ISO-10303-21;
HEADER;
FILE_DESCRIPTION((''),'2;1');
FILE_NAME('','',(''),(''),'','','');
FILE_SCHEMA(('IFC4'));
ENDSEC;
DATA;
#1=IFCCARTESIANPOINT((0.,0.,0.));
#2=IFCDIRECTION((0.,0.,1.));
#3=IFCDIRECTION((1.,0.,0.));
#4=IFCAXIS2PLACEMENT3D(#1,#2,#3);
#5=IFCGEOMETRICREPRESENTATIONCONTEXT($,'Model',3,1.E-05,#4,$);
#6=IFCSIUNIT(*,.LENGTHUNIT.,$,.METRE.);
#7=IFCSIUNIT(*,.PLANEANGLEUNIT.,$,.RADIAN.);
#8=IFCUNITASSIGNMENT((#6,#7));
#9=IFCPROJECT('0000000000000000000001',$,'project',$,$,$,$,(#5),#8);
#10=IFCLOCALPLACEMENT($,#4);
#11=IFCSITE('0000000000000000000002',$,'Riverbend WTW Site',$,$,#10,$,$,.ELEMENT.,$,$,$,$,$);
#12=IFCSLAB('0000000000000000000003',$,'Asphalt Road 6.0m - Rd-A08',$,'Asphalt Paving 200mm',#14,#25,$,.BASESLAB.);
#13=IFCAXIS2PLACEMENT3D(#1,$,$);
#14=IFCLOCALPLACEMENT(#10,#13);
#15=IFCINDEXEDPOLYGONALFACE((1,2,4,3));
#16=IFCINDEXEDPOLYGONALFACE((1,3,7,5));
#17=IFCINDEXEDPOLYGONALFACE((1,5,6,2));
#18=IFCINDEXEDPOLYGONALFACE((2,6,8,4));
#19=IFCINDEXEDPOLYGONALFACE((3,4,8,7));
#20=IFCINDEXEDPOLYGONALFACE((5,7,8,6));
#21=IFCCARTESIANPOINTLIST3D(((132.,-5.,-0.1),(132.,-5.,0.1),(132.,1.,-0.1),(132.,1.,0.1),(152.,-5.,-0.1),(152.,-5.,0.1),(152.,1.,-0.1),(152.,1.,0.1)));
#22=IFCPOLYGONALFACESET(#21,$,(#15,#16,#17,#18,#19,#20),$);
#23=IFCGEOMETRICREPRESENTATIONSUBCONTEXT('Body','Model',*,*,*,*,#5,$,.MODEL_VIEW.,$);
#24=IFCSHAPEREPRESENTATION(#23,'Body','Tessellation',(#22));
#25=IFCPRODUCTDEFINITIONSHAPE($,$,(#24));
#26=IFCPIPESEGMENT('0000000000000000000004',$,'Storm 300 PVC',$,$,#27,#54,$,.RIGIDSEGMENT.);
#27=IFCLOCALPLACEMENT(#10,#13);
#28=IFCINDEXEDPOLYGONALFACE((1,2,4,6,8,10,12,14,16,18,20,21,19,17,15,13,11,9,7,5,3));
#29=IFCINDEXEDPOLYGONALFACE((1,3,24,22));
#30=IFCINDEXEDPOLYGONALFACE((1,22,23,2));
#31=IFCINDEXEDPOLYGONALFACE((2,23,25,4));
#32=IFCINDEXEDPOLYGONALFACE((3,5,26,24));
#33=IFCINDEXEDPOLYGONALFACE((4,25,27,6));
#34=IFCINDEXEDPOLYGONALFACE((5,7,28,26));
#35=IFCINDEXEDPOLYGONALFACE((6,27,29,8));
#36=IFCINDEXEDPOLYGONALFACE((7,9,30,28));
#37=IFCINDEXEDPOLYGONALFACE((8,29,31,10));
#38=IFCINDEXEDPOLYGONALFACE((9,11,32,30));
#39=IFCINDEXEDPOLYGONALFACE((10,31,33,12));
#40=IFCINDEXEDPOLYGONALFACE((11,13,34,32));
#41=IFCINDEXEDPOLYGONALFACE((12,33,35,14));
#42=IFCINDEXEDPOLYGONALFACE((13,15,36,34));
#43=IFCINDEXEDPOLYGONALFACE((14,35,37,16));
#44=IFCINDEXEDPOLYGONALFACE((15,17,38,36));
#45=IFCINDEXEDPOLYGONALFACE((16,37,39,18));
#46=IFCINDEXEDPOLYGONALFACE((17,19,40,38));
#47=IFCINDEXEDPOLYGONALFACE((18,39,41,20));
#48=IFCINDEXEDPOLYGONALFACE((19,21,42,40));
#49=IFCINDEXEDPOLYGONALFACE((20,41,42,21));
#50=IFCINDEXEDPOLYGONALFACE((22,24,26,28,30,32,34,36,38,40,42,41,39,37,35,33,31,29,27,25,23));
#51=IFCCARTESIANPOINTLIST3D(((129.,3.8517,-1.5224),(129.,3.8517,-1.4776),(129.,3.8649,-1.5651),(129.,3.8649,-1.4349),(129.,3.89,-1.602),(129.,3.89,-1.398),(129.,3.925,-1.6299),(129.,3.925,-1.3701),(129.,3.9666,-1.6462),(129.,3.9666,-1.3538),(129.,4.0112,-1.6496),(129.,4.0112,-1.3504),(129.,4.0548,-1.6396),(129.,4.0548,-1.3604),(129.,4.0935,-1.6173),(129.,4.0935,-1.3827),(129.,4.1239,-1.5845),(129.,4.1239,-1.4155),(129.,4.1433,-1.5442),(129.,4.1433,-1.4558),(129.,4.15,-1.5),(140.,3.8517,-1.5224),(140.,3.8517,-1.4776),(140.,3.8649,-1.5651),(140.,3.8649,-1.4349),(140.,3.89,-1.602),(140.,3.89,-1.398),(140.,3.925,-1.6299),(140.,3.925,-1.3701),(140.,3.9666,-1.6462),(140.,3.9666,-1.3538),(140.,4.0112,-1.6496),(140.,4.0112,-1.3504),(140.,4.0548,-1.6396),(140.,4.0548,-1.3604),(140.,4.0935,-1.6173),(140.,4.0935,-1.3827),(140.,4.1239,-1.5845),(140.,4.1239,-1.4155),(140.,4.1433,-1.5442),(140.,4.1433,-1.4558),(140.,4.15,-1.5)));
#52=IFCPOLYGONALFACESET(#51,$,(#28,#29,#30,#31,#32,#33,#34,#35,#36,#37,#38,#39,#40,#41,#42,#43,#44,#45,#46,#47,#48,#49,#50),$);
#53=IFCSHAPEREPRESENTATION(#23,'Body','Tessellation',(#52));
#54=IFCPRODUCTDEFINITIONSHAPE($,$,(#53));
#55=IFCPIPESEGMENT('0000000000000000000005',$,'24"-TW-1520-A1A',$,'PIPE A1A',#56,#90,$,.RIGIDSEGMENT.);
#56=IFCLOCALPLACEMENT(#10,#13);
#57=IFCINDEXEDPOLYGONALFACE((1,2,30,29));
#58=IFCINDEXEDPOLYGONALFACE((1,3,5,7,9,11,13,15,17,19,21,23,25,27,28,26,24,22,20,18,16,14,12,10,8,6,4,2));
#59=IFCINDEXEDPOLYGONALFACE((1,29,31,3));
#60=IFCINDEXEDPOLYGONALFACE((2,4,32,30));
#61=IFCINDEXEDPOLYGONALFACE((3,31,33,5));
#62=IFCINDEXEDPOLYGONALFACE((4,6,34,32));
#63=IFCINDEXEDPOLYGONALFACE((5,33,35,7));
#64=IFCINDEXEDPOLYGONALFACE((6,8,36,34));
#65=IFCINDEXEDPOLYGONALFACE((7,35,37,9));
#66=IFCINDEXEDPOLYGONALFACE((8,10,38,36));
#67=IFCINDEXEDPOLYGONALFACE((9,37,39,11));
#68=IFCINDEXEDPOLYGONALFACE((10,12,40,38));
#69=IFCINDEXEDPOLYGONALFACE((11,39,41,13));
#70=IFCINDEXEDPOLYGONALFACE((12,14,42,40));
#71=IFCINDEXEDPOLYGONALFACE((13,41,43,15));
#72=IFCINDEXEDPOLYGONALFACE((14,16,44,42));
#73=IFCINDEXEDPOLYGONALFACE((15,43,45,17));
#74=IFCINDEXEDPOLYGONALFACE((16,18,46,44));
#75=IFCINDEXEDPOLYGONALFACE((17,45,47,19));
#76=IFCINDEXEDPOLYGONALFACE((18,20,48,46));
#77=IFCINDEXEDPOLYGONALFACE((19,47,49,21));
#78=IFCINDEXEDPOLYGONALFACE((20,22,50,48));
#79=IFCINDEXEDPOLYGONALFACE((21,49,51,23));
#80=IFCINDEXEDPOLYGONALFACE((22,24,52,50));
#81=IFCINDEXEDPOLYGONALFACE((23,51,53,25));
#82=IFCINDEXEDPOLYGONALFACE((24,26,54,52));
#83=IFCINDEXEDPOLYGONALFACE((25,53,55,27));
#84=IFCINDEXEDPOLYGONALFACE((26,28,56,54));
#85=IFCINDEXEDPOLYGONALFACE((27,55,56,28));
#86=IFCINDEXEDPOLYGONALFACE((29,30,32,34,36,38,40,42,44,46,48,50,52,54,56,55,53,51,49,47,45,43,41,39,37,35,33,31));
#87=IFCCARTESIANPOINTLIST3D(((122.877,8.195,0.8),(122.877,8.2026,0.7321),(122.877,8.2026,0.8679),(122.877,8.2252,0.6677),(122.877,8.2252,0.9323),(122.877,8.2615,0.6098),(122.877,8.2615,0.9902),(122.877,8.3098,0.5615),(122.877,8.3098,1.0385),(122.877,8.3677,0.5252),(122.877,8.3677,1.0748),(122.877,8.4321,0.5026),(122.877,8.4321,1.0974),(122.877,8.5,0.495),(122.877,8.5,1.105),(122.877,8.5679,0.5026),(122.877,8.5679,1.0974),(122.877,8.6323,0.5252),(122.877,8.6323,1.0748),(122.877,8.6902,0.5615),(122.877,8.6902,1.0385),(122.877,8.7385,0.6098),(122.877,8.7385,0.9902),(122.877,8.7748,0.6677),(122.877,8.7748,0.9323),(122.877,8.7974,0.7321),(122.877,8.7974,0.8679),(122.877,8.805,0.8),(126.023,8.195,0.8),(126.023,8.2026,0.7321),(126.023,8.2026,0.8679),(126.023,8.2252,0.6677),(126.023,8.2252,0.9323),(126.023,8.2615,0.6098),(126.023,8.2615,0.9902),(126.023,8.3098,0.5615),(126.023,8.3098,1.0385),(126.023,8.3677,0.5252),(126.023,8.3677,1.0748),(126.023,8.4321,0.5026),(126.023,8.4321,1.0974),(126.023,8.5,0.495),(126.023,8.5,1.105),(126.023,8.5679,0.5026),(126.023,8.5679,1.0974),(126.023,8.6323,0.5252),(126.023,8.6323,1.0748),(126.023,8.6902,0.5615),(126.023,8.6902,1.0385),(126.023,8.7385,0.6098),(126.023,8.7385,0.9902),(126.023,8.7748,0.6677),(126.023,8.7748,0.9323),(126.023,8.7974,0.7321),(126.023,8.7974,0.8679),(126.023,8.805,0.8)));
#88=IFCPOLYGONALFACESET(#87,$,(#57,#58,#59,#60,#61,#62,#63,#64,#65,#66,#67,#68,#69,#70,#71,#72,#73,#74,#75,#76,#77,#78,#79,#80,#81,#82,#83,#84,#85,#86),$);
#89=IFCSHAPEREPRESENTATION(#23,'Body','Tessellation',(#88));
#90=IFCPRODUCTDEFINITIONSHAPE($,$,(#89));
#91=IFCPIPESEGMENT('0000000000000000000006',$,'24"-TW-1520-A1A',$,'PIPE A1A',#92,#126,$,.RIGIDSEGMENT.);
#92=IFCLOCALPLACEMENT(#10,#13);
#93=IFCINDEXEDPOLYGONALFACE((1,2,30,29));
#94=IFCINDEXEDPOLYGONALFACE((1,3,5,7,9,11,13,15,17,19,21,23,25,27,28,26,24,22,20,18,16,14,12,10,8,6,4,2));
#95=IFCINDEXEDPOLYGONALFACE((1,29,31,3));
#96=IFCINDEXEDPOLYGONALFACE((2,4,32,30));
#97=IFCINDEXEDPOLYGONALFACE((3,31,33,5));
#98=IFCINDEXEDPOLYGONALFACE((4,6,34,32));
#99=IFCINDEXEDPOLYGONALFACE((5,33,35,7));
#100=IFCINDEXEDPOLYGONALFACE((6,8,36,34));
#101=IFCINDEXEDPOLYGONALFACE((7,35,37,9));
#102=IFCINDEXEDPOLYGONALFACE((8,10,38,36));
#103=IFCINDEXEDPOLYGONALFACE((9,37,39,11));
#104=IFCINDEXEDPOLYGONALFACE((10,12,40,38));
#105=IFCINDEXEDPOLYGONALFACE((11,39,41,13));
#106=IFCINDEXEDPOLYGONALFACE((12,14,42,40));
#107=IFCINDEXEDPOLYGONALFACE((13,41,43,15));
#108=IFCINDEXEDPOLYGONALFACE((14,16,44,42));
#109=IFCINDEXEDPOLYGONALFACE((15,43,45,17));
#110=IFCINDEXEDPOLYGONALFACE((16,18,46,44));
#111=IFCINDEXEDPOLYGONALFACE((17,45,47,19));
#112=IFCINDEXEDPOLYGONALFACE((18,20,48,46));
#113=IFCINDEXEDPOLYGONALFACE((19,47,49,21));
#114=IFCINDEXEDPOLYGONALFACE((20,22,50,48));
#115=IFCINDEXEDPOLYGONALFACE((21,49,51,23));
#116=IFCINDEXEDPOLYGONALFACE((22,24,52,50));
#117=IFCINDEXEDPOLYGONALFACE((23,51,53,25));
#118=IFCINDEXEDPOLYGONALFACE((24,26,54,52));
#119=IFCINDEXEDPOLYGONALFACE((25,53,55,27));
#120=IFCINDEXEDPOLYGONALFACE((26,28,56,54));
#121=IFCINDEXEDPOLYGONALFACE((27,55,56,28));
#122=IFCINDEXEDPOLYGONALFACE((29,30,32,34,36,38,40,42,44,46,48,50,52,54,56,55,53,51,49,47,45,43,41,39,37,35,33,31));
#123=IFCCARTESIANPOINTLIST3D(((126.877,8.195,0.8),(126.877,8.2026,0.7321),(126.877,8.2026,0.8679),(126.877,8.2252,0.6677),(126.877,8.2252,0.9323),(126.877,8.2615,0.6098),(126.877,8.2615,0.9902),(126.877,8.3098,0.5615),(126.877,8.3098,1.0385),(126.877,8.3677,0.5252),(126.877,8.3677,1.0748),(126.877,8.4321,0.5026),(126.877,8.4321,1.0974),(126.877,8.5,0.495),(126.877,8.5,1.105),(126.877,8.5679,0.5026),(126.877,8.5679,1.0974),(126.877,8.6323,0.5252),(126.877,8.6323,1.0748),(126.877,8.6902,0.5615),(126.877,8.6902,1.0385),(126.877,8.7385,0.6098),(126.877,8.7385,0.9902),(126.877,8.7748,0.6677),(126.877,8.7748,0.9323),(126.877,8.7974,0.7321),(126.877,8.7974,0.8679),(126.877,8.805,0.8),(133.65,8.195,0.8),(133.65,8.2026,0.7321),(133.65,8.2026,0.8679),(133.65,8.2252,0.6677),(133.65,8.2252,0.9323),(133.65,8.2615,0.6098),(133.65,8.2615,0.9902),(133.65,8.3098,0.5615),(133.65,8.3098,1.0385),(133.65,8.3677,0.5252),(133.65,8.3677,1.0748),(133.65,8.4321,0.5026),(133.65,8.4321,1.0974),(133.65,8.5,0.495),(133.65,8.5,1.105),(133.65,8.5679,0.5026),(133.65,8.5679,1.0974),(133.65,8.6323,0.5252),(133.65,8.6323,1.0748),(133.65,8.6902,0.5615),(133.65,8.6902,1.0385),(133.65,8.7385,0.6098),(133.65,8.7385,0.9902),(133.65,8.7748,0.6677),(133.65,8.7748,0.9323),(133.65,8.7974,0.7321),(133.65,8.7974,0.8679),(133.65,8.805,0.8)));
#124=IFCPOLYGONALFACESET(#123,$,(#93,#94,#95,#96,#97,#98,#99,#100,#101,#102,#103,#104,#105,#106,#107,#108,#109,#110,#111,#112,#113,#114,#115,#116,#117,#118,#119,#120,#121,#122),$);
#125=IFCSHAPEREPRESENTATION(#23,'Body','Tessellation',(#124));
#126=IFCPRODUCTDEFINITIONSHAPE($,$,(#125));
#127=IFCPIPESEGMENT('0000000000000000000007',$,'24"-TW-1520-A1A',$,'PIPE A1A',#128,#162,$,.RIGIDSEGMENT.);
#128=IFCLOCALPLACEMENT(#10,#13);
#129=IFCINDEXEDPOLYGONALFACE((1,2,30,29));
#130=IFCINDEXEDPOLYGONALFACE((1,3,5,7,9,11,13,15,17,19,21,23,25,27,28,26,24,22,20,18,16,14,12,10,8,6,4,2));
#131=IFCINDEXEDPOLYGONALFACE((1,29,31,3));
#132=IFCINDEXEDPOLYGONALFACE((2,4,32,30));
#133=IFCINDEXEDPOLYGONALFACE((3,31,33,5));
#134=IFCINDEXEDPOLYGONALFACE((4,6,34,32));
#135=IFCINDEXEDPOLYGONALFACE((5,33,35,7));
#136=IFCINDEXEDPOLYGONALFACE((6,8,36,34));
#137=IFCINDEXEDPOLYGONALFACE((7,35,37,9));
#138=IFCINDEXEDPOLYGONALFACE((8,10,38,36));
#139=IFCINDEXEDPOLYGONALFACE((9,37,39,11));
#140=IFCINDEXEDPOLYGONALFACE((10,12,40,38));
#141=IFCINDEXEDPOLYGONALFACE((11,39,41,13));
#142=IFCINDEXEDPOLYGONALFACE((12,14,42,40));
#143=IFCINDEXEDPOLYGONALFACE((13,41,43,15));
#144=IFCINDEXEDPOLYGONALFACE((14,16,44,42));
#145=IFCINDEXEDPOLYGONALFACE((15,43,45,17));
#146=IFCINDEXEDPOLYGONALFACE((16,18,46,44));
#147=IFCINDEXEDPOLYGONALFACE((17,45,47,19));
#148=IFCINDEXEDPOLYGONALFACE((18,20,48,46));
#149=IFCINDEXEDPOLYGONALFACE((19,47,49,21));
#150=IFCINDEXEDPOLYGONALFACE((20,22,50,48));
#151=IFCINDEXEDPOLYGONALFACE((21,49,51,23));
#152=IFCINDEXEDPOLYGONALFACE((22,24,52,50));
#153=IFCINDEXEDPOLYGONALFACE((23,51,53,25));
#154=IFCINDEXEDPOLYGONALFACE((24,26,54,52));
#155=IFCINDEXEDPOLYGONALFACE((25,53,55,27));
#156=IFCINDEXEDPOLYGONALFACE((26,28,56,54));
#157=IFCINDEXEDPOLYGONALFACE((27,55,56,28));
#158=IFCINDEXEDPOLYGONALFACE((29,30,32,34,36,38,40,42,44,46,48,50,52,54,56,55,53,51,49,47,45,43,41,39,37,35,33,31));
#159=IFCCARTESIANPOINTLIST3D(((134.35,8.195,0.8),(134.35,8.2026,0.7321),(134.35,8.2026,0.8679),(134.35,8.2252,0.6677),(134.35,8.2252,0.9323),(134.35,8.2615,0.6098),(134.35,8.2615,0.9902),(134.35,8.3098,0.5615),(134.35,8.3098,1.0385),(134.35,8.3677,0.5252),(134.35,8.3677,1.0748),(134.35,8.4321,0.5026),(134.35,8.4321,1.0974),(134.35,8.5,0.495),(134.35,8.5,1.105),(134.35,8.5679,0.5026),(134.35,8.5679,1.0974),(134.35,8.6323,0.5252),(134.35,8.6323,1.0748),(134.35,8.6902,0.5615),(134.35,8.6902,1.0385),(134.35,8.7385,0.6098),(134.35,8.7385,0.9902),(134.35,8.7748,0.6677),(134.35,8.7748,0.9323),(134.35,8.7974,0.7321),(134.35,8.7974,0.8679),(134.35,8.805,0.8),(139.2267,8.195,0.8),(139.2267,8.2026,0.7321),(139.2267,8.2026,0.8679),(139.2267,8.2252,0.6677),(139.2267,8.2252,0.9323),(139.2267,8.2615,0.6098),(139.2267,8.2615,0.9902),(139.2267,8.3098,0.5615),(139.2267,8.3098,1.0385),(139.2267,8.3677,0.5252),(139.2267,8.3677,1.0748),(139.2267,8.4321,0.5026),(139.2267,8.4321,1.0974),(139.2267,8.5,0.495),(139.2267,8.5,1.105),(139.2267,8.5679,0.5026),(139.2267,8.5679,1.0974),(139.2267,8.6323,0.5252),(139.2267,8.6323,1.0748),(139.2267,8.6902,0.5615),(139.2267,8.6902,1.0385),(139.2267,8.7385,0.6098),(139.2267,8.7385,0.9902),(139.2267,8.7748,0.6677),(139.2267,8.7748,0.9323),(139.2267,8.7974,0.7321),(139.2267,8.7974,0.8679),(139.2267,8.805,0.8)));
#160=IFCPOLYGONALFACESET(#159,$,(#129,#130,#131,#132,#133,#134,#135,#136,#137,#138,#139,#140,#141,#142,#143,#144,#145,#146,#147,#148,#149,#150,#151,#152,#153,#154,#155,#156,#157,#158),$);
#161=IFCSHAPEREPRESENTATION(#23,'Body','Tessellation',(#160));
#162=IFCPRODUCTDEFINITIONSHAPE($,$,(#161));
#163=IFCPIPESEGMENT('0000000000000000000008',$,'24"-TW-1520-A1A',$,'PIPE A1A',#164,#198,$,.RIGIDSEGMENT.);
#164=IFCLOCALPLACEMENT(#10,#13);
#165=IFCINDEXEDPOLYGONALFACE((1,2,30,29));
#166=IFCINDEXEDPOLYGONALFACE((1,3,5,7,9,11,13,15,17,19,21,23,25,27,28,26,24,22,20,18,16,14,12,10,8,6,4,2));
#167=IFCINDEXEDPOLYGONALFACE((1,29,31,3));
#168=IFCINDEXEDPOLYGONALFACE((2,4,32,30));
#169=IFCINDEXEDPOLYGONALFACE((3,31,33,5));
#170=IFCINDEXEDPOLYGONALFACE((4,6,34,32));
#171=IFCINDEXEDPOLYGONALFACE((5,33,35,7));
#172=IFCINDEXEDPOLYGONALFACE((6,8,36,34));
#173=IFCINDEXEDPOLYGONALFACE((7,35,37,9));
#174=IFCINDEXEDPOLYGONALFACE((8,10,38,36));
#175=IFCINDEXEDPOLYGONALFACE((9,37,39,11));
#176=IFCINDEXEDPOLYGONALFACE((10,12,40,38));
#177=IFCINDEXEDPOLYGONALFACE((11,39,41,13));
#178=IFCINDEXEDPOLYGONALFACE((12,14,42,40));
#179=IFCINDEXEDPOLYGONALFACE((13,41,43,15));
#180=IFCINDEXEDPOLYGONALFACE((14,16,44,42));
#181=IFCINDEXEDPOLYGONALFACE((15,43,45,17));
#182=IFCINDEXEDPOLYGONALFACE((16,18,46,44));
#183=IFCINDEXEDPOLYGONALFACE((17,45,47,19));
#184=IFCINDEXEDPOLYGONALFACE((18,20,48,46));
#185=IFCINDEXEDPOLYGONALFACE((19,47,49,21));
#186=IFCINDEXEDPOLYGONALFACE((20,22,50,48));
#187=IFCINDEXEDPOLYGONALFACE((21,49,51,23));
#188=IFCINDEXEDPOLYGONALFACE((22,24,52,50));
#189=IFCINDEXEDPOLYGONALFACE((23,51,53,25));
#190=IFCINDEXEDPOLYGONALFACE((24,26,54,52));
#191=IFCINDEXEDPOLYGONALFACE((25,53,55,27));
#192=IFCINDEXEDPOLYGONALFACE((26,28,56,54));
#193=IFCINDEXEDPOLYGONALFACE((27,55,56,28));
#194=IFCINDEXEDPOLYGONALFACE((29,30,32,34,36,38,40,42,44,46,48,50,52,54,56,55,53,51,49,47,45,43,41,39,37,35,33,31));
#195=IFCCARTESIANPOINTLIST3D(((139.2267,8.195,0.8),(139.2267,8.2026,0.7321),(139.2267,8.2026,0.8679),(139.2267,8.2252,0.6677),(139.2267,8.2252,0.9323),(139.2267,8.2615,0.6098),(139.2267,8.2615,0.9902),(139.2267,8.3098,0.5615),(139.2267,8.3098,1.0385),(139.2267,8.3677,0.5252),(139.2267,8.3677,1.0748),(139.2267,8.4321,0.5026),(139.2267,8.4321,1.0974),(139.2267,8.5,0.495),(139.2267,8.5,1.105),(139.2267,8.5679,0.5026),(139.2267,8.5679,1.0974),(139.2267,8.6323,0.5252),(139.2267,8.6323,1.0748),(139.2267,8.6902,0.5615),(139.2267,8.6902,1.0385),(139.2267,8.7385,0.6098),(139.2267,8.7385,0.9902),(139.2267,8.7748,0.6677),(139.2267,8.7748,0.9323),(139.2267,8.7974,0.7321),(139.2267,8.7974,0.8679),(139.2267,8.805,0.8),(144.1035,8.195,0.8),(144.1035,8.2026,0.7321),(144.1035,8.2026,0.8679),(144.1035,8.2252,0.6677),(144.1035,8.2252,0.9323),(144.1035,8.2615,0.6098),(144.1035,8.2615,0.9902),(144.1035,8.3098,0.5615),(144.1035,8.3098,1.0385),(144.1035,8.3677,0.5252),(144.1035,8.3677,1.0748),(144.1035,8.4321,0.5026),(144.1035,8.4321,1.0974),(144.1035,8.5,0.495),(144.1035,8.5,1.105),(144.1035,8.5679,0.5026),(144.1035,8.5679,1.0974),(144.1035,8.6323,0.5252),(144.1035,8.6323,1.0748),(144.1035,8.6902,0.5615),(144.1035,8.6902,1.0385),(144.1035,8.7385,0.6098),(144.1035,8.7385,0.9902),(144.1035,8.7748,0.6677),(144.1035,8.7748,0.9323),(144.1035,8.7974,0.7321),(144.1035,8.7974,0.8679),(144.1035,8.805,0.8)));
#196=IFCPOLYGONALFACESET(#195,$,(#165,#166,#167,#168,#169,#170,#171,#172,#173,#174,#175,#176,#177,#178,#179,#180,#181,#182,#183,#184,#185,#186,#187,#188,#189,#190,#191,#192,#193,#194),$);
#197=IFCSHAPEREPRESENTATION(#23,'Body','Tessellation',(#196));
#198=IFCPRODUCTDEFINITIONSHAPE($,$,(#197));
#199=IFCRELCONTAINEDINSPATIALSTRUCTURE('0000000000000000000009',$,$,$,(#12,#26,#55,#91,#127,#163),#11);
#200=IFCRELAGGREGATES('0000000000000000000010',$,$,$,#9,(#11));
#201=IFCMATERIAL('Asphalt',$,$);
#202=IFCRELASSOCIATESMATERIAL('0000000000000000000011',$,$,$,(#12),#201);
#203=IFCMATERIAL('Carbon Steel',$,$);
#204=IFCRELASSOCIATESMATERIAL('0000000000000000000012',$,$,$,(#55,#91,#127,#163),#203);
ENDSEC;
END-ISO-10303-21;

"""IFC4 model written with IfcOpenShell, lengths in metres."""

from ifc_helpers import new_model, si_unit, frame, origin_with_axes, origin_2d, place, context, subcontext, project, spatial, rectangle, circle, extrude, material, element, save


model = new_model("IFC4")

# Units and contexts
model_context = context("Model", 3, precision=1e-05, world=origin_with_axes())
body_context = subcontext(model_context, "Body", "Model", "MODEL_VIEW")
ifc_project = project(units=[si_unit("LENGTHUNIT", "METRE"), si_unit("PLANEANGLEUNIT", "RADIAN")], contexts=[model_context])

# Site
site_placement = place(None, origin_with_axes())
site = spatial("IfcSite", under=ifc_project, at=site_placement, Name="Riverbend WTW Site", CompositionType="ELEMENT")

# Slab
ifc_material_1 = material(Name="Asphalt")
slab_placement = place(None, frame((142.0, -2.0, 0.0), z_axis=(0.0, 0.0, 1.0), x_axis=(1.0, 0.0, 0.0)))
element("IfcSlab", 1, at=slab_placement, inside=site, material=ifc_material_1, Name="Asphalt Road 6.0m - Rd-A08", ObjectType="Asphalt Paving 200mm", PredefinedType="BASESLAB", context=body_context, shape_type="SweptSolid", body=[
    extrude(rectangle(XDim=20.0, YDim=6.0, at=origin_2d()), frame((0.0, 0.0, -0.1), z_axis=(0.0, 0.0, 1.0), x_axis=(1.0, 0.0, 0.0)), (0.0, 0.0, 1.0), 0.2),
])

# Pipe segments
pipe_segment_1_placement = place(None, frame((129.0, 4.0, -1.5), z_axis=(0.0, 0.0, 1.0), x_axis=(1.0, 0.0, 0.0)))
element("IfcPipeSegment", 2, at=pipe_segment_1_placement, inside=site, Name="Storm 300 PVC", PredefinedType="RIGIDSEGMENT", context=body_context, shape_type="SweptSolid", body=[
    extrude(circle(Radius=0.15, at=origin_2d()), frame((0.0, 0.0, 0.0), z_axis=(1.0, 0.0, 0.0), x_axis=(0.0, 1.0, 0.0)), (0.0, 0.0, 1.0), 11.0),
])
ifc_material_2 = material(Name="Carbon Steel")
pipe_segment_2_placement = place(None, frame((122.877, 8.5, 0.8), z_axis=(0.0, 0.0, 1.0), x_axis=(1.0, 0.0, 0.0)))
element("IfcPipeSegment", 3, at=pipe_segment_2_placement, inside=site, material=ifc_material_2, Name="24\"-TW-1520-A1A", ObjectType="PIPE A1A", PredefinedType="RIGIDSEGMENT", context=body_context, shape_type="SweptSolid", body=[
    extrude(circle(Radius=0.305, at=origin_2d()), frame((0.0, 0.0, 0.0), z_axis=(1.0, 0.0, 0.0), x_axis=(0.0, 1.0, 0.0)), (0.0, 0.0, 1.0), 3.146),
])
pipe_segment_3_placement = place(None, frame((126.877, 8.5, 0.8), z_axis=(0.0, 0.0, 1.0), x_axis=(1.0, 0.0, 0.0)))
element("IfcPipeSegment", 4, at=pipe_segment_3_placement, inside=site, material=ifc_material_2, Name="24\"-TW-1520-A1A", ObjectType="PIPE A1A", PredefinedType="RIGIDSEGMENT", context=body_context, shape_type="SweptSolid", body=[
    extrude(circle(Radius=0.305, at=origin_2d()), frame((0.0, 0.0, 0.0), z_axis=(1.0, 0.0, 0.0), x_axis=(0.0, 1.0, 0.0)), (0.0, 0.0, 1.0), 6.773),
])
pipe_segment_4_placement = place(None, frame((134.35, 8.5, 0.8), z_axis=(0.0, 0.0, 1.0), x_axis=(1.0, 0.0, 0.0)))
element("IfcPipeSegment", 5, at=pipe_segment_4_placement, inside=site, material=ifc_material_2, Name="24\"-TW-1520-A1A", ObjectType="PIPE A1A", PredefinedType="RIGIDSEGMENT", context=body_context, shape_type="SweptSolid", body=[
    extrude(circle(Radius=0.305, at=origin_2d()), frame((0.0, 0.0, 0.0), z_axis=(1.0, 0.0, 0.0), x_axis=(0.0, 1.0, 0.0)), (0.0, 0.0, 1.0), 4.8767),
])
pipe_segment_5_placement = place(None, frame((139.2267, 8.5, 0.8), z_axis=(0.0, 0.0, 1.0), x_axis=(1.0, 0.0, 0.0)))
element("IfcPipeSegment", 6, at=pipe_segment_5_placement, inside=site, material=ifc_material_2, Name="24\"-TW-1520-A1A", ObjectType="PIPE A1A", PredefinedType="RIGIDSEGMENT", context=body_context, shape_type="SweptSolid", body=[
    extrude(circle(Radius=0.305, at=origin_2d()), frame((0.0, 0.0, 0.0), z_axis=(1.0, 0.0, 0.0), x_axis=(0.0, 1.0, 0.0)), (0.0, 0.0, 1.0), 4.8768),
])

save(model, "model.ifc")
